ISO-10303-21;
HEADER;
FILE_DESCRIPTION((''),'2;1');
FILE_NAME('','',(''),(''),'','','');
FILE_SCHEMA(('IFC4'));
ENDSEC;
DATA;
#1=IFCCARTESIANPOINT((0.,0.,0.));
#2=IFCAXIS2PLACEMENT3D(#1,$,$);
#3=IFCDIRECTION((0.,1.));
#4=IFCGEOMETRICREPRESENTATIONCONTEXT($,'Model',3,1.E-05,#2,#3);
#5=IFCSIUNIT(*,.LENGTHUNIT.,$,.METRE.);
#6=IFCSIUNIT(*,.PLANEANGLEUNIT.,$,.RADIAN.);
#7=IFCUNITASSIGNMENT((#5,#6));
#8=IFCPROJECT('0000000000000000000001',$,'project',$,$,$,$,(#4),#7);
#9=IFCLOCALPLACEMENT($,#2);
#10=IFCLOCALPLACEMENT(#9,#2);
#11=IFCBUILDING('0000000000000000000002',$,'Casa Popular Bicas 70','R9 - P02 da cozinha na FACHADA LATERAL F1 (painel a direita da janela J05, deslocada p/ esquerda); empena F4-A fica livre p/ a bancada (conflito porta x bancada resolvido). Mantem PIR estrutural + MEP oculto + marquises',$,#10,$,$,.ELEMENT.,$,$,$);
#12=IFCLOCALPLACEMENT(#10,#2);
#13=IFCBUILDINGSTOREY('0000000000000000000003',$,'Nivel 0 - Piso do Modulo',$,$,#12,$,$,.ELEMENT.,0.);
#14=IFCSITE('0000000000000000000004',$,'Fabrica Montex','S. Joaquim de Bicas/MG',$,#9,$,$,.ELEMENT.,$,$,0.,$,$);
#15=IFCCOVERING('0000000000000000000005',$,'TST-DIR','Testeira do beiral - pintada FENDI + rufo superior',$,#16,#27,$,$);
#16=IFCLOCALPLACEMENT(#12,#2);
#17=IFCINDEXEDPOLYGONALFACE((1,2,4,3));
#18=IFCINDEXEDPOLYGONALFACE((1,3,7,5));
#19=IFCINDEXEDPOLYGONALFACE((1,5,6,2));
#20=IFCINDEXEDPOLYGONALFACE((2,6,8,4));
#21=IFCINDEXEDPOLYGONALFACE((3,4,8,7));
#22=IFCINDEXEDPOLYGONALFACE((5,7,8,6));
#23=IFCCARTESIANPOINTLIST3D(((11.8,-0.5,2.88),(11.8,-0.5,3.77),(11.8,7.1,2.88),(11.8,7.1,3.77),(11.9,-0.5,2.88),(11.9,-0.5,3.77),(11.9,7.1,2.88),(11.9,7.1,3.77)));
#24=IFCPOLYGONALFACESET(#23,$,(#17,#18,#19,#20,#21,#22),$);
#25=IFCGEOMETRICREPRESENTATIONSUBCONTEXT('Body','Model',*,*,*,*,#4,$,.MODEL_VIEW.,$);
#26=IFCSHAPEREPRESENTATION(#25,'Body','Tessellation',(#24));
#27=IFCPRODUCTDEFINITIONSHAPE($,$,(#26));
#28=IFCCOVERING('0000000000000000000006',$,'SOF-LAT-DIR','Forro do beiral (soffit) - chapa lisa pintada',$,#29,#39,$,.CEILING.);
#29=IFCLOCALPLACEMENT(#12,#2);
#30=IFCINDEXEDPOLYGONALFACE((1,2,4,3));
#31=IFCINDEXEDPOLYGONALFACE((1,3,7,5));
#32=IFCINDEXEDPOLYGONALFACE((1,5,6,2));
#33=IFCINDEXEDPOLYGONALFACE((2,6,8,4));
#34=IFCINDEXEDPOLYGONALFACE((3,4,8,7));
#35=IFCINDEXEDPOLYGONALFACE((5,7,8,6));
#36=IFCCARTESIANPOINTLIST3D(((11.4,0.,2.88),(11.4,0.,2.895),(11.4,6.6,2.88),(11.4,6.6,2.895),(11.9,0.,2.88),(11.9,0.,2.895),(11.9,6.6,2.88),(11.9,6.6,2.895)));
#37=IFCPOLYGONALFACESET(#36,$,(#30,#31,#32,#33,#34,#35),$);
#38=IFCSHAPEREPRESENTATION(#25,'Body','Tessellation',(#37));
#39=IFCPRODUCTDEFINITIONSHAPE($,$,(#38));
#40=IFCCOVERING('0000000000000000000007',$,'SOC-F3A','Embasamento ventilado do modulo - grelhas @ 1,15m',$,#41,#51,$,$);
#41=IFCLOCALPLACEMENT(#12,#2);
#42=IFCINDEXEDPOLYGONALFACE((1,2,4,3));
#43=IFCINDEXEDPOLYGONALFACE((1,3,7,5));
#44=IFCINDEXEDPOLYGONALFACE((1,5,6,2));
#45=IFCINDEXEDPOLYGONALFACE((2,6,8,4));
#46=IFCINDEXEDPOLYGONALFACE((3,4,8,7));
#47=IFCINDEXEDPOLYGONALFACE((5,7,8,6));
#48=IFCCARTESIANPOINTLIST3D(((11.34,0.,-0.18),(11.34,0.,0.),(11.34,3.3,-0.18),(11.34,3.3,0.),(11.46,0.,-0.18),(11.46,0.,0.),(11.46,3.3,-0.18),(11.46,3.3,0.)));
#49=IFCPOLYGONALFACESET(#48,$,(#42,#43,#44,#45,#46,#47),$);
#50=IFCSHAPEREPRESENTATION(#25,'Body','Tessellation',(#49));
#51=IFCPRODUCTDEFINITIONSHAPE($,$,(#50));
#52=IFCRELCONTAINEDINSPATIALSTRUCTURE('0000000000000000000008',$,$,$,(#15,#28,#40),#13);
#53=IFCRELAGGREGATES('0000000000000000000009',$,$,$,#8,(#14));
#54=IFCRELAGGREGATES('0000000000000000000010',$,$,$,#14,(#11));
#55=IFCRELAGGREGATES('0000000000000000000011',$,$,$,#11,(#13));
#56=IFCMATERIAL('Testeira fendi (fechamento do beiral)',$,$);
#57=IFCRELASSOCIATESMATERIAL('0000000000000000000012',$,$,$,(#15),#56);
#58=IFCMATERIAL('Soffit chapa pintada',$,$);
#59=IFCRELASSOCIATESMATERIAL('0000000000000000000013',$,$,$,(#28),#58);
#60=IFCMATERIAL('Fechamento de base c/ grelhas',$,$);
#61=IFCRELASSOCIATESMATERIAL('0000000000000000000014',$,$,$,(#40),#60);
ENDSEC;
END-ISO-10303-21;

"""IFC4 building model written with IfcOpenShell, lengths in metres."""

from ifc_helpers import new_model, si_unit, direction, frame, frame_2d, origin, place, context, subcontext, project, spatial, rectangle, extrude, material, element, save


model = new_model("IFC4")

# Units and contexts
model_context = context("Model", 3, precision=1e-05, world=origin(), true_north=direction((0.0, 1.0)))
body_context = subcontext(model_context, "Body", "Model", "MODEL_VIEW")
ifc_project = project(units=[si_unit("LENGTHUNIT", "METRE"), si_unit("PLANEANGLEUNIT", "RADIAN")], contexts=[model_context])

# Site, building, storey
site_placement = place(None, origin())
site = spatial("IfcSite", under=ifc_project, at=site_placement, Name="Fabrica Montex", Description="S. Joaquim de Bicas/MG", CompositionType="ELEMENT", RefElevation=0.0)
building_placement = place(site_placement, origin())
building = spatial("IfcBuilding", under=site, at=building_placement, Name="Casa Popular Bicas 70", Description="R9 - P02 da cozinha na FACHADA LATERAL F1 (painel a direita da janela J05, deslocada p/ esquerda); empena F4-A fica livre p/ a bancada (conflito porta x bancada resolvido). Mantem PIR estrutural + MEP oculto + marquises", CompositionType="ELEMENT")
storey_placement = place(building_placement, origin())
storey = spatial("IfcBuildingStorey", under=building, at=storey_placement, Name="Nivel 0 - Piso do Modulo", CompositionType="ELEMENT", Elevation=0.0)

# Coverings
ifc_material_1 = material(Name="Testeira fendi (fechamento do beiral)")
covering_1_placement = place(storey_placement, frame((11.85, -0.5, 2.88), x_axis=(0.0, 1.0, 0.0)))
element("IfcCovering", 1, at=covering_1_placement, inside=storey, material=ifc_material_1, Name="TST-DIR", Description="Testeira do beiral - pintada FENDI + rufo superior", context=body_context, shape_type="SweptSolid", body=[
    extrude(rectangle(XDim=7.6, YDim=0.1, at=frame_2d((3.8, 0.0))), origin(), (0.0, 0.0, 1.0), 0.89),
])
ifc_material_2 = material(Name="Soffit chapa pintada")
covering_2_placement = place(storey_placement, frame((11.4, 0.0, 2.88)))
element("IfcCovering", 2, at=covering_2_placement, inside=storey, material=ifc_material_2, Name="SOF-LAT-DIR", Description="Forro do beiral (soffit) - chapa lisa pintada", PredefinedType="CEILING", context=body_context, shape_type="SweptSolid", body=[
    extrude(rectangle(XDim=0.5, YDim=6.6, at=frame_2d((0.25, 3.3))), origin(), (0.0, 0.0, 1.0), 0.015),
])
ifc_material_3 = material(Name="Fechamento de base c/ grelhas")
covering_3_placement = place(storey_placement, frame((11.4, 0.0, -0.18), x_axis=(0.0, 1.0, 0.0)))
element("IfcCovering", 3, at=covering_3_placement, inside=storey, material=ifc_material_3, Name="SOC-F3A", Description="Embasamento ventilado do modulo - grelhas @ 1,15m", context=body_context, shape_type="SweptSolid", body=[
    extrude(rectangle(XDim=3.3, YDim=0.12, at=frame_2d((1.65, 0.0))), origin(), (0.0, 0.0, 1.0), 0.18),
])

save(model, "model.ifc")
